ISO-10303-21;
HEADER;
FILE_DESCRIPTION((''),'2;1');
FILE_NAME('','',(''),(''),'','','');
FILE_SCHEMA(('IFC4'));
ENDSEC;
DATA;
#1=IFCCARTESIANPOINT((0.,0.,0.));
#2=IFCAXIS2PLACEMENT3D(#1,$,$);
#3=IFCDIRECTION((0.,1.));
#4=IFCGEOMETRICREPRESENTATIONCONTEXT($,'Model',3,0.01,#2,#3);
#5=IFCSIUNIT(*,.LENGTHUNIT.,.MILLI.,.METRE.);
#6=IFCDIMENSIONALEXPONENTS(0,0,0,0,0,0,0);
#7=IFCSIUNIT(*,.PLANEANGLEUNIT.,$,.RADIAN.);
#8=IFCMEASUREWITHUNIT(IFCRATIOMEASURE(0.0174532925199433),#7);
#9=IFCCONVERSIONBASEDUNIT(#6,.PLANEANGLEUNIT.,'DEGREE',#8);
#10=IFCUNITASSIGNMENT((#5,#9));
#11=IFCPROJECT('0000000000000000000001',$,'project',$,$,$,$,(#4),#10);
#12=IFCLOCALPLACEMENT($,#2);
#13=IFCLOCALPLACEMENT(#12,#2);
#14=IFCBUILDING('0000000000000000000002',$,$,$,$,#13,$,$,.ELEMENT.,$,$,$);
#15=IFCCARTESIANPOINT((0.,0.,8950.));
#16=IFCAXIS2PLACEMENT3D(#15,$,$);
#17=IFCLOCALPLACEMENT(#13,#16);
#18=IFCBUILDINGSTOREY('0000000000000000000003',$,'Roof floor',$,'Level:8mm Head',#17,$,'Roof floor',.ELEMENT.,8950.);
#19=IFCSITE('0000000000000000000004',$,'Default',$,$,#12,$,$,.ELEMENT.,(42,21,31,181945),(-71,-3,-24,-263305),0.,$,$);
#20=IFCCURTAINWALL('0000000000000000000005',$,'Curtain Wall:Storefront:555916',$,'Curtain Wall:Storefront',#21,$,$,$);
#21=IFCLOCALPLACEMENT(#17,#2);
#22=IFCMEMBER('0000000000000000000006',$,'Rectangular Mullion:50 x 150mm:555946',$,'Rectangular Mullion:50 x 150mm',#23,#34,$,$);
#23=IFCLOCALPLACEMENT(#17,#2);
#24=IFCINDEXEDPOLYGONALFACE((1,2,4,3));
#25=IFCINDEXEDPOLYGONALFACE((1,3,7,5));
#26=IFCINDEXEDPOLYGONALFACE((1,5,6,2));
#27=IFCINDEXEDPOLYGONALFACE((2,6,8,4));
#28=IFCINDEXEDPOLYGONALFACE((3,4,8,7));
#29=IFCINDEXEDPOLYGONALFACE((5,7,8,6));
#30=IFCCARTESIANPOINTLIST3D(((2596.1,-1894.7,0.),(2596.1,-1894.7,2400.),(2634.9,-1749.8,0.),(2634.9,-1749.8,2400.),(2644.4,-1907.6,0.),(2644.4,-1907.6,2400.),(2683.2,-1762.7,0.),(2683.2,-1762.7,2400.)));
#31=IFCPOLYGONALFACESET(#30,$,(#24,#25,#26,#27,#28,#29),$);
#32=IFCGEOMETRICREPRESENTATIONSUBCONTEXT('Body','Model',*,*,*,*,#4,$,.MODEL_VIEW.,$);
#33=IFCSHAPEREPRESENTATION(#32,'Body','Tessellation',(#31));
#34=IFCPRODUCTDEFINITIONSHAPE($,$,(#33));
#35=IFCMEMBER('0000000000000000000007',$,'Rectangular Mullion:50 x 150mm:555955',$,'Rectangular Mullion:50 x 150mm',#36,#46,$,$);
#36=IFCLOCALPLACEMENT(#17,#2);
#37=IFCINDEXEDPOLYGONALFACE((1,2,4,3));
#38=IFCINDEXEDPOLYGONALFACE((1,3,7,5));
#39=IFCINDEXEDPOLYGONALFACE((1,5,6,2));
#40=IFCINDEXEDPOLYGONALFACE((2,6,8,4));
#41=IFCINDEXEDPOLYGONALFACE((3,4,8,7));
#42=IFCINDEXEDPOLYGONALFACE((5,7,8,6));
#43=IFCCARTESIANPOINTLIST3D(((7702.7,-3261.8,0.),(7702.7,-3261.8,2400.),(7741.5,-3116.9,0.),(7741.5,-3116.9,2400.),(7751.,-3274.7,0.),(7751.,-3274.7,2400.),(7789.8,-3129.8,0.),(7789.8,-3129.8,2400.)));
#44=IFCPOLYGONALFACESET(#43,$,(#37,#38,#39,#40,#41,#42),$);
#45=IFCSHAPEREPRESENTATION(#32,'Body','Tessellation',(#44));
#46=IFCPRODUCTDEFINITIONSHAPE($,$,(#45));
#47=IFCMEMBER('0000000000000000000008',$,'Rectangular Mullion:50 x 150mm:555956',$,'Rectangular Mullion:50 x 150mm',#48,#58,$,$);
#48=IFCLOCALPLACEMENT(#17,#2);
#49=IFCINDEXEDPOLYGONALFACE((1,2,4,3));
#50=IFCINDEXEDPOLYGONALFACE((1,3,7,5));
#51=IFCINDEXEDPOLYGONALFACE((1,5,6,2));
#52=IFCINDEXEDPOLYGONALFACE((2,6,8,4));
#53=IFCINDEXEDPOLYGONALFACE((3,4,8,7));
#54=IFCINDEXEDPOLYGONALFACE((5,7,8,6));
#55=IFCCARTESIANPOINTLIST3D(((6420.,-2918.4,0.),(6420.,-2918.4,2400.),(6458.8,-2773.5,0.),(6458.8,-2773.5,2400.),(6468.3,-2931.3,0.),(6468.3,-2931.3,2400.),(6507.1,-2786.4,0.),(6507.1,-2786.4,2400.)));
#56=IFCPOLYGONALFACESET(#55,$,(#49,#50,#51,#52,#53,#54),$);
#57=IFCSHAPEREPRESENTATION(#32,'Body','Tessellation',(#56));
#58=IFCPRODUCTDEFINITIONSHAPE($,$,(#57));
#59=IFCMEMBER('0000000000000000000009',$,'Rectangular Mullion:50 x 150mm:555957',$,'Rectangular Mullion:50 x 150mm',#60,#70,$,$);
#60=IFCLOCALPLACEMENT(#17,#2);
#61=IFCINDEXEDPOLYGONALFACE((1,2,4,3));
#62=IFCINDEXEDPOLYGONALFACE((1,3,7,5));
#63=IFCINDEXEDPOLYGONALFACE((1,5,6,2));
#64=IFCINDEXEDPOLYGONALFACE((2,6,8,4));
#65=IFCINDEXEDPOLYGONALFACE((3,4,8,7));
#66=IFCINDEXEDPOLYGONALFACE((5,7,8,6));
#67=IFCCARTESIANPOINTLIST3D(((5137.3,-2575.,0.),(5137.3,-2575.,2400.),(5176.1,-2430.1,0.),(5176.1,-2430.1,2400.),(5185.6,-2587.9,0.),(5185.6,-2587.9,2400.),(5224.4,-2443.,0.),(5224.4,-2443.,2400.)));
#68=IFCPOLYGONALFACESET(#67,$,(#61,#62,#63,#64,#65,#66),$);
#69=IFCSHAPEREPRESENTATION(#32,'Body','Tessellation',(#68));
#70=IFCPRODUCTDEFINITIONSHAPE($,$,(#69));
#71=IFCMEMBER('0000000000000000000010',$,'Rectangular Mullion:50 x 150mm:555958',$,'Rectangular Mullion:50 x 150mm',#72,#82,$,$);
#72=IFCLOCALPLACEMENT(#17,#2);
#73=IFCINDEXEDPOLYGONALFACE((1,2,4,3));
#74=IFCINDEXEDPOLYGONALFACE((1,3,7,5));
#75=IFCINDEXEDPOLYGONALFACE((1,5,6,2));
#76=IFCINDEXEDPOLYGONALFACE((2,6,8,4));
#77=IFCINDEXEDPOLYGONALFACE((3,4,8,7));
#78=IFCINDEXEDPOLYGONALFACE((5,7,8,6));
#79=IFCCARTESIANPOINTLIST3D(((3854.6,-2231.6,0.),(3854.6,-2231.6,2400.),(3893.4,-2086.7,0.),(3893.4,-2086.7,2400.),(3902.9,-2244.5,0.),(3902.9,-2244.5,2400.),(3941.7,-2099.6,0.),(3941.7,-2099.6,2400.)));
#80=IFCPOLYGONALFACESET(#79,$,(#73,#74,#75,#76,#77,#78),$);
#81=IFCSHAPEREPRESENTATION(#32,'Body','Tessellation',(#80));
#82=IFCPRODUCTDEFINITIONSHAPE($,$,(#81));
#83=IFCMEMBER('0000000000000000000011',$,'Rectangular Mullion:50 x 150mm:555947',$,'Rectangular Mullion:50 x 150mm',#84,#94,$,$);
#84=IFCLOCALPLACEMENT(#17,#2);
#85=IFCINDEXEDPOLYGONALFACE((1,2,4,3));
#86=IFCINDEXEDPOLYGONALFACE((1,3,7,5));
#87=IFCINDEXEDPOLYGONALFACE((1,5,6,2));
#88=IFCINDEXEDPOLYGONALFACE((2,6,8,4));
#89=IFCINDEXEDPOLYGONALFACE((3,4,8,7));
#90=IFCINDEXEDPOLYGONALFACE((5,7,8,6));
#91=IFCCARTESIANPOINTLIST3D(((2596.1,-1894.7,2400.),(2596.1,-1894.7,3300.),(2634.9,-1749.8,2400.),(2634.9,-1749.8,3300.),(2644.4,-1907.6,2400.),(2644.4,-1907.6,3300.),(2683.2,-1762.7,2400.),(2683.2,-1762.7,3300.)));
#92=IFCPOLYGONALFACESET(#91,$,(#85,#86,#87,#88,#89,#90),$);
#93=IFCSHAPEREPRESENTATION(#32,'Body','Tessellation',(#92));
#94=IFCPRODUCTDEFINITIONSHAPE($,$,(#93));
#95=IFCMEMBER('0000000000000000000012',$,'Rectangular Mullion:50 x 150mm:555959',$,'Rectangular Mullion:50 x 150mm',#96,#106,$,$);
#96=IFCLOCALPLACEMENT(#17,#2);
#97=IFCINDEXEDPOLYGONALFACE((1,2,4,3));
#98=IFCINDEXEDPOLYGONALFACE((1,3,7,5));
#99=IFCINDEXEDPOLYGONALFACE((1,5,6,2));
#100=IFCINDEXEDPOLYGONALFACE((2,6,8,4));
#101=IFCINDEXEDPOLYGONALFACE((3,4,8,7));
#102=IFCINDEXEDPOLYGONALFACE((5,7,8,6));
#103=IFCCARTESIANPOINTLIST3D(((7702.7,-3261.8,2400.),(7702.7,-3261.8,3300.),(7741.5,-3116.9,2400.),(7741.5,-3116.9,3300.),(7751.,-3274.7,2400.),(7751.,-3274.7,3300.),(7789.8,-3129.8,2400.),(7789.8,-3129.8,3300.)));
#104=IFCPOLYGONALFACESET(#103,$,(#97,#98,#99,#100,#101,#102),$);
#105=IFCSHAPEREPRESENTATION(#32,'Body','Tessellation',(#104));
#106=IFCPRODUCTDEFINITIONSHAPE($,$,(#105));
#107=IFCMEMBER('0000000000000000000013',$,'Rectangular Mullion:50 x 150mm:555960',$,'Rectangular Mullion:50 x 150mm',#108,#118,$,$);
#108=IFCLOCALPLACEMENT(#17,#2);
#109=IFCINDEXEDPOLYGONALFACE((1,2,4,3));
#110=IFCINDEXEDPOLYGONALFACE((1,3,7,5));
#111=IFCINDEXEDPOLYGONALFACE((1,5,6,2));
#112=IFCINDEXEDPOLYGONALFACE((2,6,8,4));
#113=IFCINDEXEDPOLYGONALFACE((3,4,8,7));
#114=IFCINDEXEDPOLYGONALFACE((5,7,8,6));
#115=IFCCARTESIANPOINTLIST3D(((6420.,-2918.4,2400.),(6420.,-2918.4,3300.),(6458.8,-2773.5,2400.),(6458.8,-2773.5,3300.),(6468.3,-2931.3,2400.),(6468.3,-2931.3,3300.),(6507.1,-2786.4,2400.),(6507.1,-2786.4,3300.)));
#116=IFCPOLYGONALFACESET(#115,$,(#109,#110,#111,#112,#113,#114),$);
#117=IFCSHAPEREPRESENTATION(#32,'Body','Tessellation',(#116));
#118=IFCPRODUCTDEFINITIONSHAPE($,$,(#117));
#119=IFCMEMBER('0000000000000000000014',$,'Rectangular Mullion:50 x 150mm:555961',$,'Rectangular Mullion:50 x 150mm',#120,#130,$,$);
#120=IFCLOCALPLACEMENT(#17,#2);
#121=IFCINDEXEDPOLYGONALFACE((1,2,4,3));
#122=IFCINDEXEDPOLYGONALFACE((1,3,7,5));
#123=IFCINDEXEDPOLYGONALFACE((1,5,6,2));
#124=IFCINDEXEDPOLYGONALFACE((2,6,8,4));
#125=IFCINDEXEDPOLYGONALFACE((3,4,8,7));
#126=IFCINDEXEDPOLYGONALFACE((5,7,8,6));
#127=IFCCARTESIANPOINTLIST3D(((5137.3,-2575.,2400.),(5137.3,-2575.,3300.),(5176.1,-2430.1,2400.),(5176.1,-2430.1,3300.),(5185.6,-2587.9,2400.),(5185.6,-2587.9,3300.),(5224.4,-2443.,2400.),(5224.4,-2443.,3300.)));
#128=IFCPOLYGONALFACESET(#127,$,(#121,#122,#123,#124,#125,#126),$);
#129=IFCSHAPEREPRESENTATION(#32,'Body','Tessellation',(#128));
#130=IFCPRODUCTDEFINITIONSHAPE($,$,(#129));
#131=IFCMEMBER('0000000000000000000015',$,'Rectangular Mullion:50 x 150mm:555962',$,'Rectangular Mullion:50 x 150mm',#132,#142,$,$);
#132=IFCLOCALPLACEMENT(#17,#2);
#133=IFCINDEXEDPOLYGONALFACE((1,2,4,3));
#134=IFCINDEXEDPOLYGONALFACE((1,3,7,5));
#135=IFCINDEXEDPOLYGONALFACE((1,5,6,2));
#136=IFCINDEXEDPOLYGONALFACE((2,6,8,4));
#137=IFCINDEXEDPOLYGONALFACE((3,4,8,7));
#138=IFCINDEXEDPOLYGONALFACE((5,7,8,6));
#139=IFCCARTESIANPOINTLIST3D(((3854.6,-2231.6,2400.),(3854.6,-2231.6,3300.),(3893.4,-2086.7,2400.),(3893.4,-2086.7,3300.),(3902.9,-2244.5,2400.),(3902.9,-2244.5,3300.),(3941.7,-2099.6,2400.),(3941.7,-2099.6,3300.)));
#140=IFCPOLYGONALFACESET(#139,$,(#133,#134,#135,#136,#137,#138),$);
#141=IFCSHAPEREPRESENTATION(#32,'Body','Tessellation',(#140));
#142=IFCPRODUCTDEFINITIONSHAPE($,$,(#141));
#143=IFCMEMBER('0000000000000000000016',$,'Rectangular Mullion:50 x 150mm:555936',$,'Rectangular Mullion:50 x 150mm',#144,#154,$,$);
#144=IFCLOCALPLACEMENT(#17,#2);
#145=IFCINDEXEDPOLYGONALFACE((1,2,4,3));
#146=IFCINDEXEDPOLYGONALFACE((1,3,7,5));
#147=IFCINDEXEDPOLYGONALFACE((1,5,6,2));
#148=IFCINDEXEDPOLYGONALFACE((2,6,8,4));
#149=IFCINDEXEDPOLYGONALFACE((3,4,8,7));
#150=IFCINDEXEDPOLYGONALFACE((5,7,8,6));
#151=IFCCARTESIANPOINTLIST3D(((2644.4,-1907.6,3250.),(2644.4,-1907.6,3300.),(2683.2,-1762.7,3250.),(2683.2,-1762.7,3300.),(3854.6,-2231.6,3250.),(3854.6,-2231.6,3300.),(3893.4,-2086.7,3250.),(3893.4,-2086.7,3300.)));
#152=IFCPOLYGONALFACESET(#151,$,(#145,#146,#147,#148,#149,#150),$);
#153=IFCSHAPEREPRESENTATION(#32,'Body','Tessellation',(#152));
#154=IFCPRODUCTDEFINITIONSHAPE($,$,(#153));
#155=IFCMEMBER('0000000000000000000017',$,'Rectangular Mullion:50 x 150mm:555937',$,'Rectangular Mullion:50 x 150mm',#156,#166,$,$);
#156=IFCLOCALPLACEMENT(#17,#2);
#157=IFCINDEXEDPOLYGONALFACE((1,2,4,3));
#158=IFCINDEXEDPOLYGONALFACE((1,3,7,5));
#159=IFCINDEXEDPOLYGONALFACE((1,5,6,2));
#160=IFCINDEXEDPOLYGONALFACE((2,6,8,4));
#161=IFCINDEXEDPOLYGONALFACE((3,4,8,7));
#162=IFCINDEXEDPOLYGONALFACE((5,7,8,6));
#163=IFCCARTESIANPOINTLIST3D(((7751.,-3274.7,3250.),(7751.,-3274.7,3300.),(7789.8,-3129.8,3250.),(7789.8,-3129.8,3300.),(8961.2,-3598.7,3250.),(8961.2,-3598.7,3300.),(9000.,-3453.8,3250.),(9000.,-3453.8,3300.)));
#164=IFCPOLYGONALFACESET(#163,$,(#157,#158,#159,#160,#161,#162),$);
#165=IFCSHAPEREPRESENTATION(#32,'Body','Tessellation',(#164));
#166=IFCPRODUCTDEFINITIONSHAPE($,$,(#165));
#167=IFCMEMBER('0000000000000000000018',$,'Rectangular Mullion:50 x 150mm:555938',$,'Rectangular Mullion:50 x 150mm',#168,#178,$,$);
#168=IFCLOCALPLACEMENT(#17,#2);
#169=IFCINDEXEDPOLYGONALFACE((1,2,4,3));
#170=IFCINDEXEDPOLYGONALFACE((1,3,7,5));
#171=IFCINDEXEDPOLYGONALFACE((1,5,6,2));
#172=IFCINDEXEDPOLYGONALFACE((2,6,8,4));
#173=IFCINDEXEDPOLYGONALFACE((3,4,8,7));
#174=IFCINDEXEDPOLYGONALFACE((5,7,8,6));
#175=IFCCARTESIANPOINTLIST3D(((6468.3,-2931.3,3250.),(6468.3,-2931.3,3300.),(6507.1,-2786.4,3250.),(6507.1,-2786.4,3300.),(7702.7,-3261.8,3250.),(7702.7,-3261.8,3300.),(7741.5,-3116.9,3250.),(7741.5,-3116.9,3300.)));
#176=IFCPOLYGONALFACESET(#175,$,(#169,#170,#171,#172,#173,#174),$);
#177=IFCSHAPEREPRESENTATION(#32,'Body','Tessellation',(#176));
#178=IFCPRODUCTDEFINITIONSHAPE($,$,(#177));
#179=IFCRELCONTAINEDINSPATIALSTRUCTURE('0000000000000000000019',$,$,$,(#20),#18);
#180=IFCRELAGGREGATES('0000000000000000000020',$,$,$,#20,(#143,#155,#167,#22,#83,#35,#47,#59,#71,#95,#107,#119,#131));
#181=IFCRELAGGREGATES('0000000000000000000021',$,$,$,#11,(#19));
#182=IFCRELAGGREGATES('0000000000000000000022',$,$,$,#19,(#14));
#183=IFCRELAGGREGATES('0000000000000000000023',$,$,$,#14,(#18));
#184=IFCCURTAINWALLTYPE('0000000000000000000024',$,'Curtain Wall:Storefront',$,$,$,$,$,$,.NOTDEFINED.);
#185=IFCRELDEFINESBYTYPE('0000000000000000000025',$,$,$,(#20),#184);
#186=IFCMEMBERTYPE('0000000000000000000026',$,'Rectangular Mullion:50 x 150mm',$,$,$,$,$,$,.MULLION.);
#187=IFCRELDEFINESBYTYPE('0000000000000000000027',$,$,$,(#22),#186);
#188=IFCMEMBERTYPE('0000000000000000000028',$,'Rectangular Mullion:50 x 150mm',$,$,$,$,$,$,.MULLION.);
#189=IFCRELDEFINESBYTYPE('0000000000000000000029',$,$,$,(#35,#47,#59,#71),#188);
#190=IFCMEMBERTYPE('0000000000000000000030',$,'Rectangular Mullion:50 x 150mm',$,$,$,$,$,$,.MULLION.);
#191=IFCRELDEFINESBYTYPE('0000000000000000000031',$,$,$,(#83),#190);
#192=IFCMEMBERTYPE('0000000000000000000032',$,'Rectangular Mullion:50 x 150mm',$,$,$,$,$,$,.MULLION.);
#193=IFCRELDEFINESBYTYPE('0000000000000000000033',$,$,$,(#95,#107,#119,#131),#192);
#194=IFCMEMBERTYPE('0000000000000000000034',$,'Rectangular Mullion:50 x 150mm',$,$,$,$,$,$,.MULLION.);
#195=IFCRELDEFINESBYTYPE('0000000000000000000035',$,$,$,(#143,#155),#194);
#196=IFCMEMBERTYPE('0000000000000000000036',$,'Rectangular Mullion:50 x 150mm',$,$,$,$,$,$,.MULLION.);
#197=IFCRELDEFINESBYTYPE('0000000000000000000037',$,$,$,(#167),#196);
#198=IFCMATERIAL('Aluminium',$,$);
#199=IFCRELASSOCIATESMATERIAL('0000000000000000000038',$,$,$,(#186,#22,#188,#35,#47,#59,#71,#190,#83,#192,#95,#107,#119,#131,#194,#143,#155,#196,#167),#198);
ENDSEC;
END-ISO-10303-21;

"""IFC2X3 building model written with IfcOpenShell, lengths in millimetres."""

from ifc_helpers import new_model, entity, si_unit, converted_unit, direction, frame, origin, origin_2d_with_axis, place, context, subcontext, project, spatial, rectangle, extrude, source, transform, mapped, material, type_object, type_shapes, element, aggregate, save


model = new_model("IFC2X3")

# Units and contexts
model_context = context("Model", 3, precision=0.01, world=origin(), true_north=direction((0.0, 1.0)))
body_context = subcontext(model_context, "Body", "Model", "MODEL_VIEW")
ifc_project = project(units=[si_unit("LENGTHUNIT", "METRE", prefix="MILLI"), converted_unit("PLANEANGLEUNIT", "DEGREE", entity("IfcRatioMeasure", 0.0174532925199433), si_unit("PLANEANGLEUNIT", "RADIAN"), dimensions=[0, 0, 0, 0, 0, 0, 0])], contexts=[model_context])

# Site, building, storey
site_placement = place(None, origin())
site = spatial("IfcSite", under=ifc_project, at=site_placement, Name="Default", CompositionType="ELEMENT", RefLatitude=(42, 21, 31, 181945), RefLongitude=(-71, -3, -24, -263305), RefElevation=0.0)
building_placement = place(site_placement, origin())
building = spatial("IfcBuilding", under=site, at=building_placement, CompositionType="ELEMENT")
storey_placement = place(building_placement, frame((0.0, 0.0, 8950.0)))
storey = spatial("IfcBuildingStorey", under=building, at=storey_placement, Name="Roof floor", ObjectType="Level:8mm Head", LongName="Roof floor", CompositionType="ELEMENT", Elevation=8950.0)

# Curtain wall, members
curtain_wall_type = type_object("IfcCurtainWallType", Name="Curtain Wall:Storefront", PredefinedType="NOTDEFINED")
curtain_wall_placement = place(storey_placement, frame((0.0, 0.0, -8950.0)))
curtain_wall = element("IfcCurtainWall", 1, at=curtain_wall_placement, inside=storey, type_object=curtain_wall_type, Name="Curtain Wall:Storefront:555916", ObjectType="Curtain Wall:Storefront")
ifc_material_1 = material(Name="Aluminium")
member_type_1 = type_object("IfcMemberType", Name="Rectangular Mullion:50 x 150mm", PredefinedType="MULLION", material=ifc_material_1)
shared_shape_1 = source(origin(), body_context, "Body", "SweptSolid", [
    extrude(rectangle(XDim=150.0, YDim=50.0, at=origin_2d_with_axis()), frame((-25.0, 0.0, -2400.0), z_axis=(0.0, 0.0, 1.0), x_axis=(0.0, -1.0, 0.0)), (0.0, 0.0, 1.0), 2400.0),
])
type_shapes(member_type_1, [shared_shape_1])
member_1_placement = place(storey_placement, frame((2615.5, -1822.2, 0.0), z_axis=(0.0, 0.0, -1.0), x_axis=(-0.965983, 0.258607, 0.0)))
member_1 = element("IfcMember", 2, at=member_1_placement, type_object=member_type_1, material=ifc_material_1, Name="Rectangular Mullion:50 x 150mm:555946", ObjectType="Rectangular Mullion:50 x 150mm", context=body_context, shape_type="MappedRepresentation", body=[
    mapped(shared_shape_1, transform((0.0, 0.0, 0.0), scale=1.0)),
])
member_type_2 = type_object("IfcMemberType", Name="Rectangular Mullion:50 x 150mm", PredefinedType="MULLION", material=ifc_material_1)
shared_shape_2 = source(origin(), body_context, "Body", "SweptSolid", [
    extrude(rectangle(XDim=150.0, YDim=50.0, at=origin_2d_with_axis()), frame((0.0, 0.0, -2400.0), z_axis=(0.0, 0.0, 1.0), x_axis=(0.0, -1.0, 0.0)), (0.0, 0.0, 1.0), 2400.0),
])
type_shapes(member_type_2, [shared_shape_2])
member_2_placement = place(storey_placement, frame((7746.2, -3195.8, 0.0), z_axis=(0.0, 0.0, -1.0), x_axis=(-0.965983, 0.258607, 0.0)))
member_2 = element("IfcMember", 3, at=member_2_placement, type_object=member_type_2, material=ifc_material_1, Name="Rectangular Mullion:50 x 150mm:555955", ObjectType="Rectangular Mullion:50 x 150mm", context=body_context, shape_type="MappedRepresentation", body=[
    mapped(shared_shape_2, transform((0.0, 0.0, 0.0), scale=1.0)),
])
member_3_placement = place(storey_placement, frame((6463.5, -2852.4, 0.0), z_axis=(0.0, 0.0, -1.0), x_axis=(-0.965983, 0.258607, 0.0)))
member_3 = element("IfcMember", 4, at=member_3_placement, type_object=member_type_2, material=ifc_material_1, Name="Rectangular Mullion:50 x 150mm:555956", ObjectType="Rectangular Mullion:50 x 150mm", context=body_context, shape_type="MappedRepresentation", body=[
    mapped(shared_shape_2, transform((0.0, 0.0, 0.0), scale=1.0)),
])
member_4_placement = place(storey_placement, frame((5180.8, -2509.0, 0.0), z_axis=(0.0, 0.0, -1.0), x_axis=(-0.965983, 0.258607, 0.0)))
member_4 = element("IfcMember", 5, at=member_4_placement, type_object=member_type_2, material=ifc_material_1, Name="Rectangular Mullion:50 x 150mm:555957", ObjectType="Rectangular Mullion:50 x 150mm", context=body_context, shape_type="MappedRepresentation", body=[
    mapped(shared_shape_2, transform((0.0, 0.0, 0.0), scale=1.0)),
])
member_5_placement = place(storey_placement, frame((3898.2, -2165.6, 0.0), z_axis=(0.0, 0.0, -1.0), x_axis=(-0.965983, 0.258607, 0.0)))
member_5 = element("IfcMember", 6, at=member_5_placement, type_object=member_type_2, material=ifc_material_1, Name="Rectangular Mullion:50 x 150mm:555958", ObjectType="Rectangular Mullion:50 x 150mm", context=body_context, shape_type="MappedRepresentation", body=[
    mapped(shared_shape_2, transform((0.0, 0.0, 0.0), scale=1.0)),
])
member_type_3 = type_object("IfcMemberType", Name="Rectangular Mullion:50 x 150mm", PredefinedType="MULLION", material=ifc_material_1)
shared_shape_3 = source(origin(), body_context, "Body", "SweptSolid", [
    extrude(rectangle(XDim=150.0, YDim=50.0, at=origin_2d_with_axis()), frame((-25.0, 0.0, -900.0), z_axis=(0.0, 0.0, 1.0), x_axis=(0.0, -1.0, 0.0)), (0.0, 0.0, 1.0), 900.0),
])
type_shapes(member_type_3, [shared_shape_3])
member_6_placement = place(storey_placement, frame((2615.5, -1822.2, 2400.0), z_axis=(0.0, 0.0, -1.0), x_axis=(-0.965983, 0.258607, 0.0)))
member_6 = element("IfcMember", 7, at=member_6_placement, type_object=member_type_3, material=ifc_material_1, Name="Rectangular Mullion:50 x 150mm:555947", ObjectType="Rectangular Mullion:50 x 150mm", context=body_context, shape_type="MappedRepresentation", body=[
    mapped(shared_shape_3, transform((0.0, 0.0, 0.0), scale=1.0)),
])
member_type_4 = type_object("IfcMemberType", Name="Rectangular Mullion:50 x 150mm", PredefinedType="MULLION", material=ifc_material_1)
shared_shape_4 = source(origin(), body_context, "Body", "SweptSolid", [
    extrude(rectangle(XDim=150.0, YDim=50.0, at=origin_2d_with_axis()), frame((0.0, 0.0, -900.0), z_axis=(0.0, 0.0, 1.0), x_axis=(0.0, -1.0, 0.0)), (0.0, 0.0, 1.0), 900.0),
])
type_shapes(member_type_4, [shared_shape_4])
member_7_placement = place(storey_placement, frame((7746.2, -3195.8, 2400.0), z_axis=(0.0, 0.0, -1.0), x_axis=(-0.965983, 0.258607, 0.0)))
member_7 = element("IfcMember", 8, at=member_7_placement, type_object=member_type_4, material=ifc_material_1, Name="Rectangular Mullion:50 x 150mm:555959", ObjectType="Rectangular Mullion:50 x 150mm", context=body_context, shape_type="MappedRepresentation", body=[
    mapped(shared_shape_4, transform((0.0, 0.0, 0.0), scale=1.0)),
])
member_8_placement = place(storey_placement, frame((6463.5, -2852.4, 2400.0), z_axis=(0.0, 0.0, -1.0), x_axis=(-0.965983, 0.258607, 0.0)))
member_8 = element("IfcMember", 9, at=member_8_placement, type_object=member_type_4, material=ifc_material_1, Name="Rectangular Mullion:50 x 150mm:555960", ObjectType="Rectangular Mullion:50 x 150mm", context=body_context, shape_type="MappedRepresentation", body=[
    mapped(shared_shape_4, transform((0.0, 0.0, 0.0), scale=1.0)),
])
member_9_placement = place(storey_placement, frame((5180.8, -2509.0, 2400.0), z_axis=(0.0, 0.0, -1.0), x_axis=(-0.965983, 0.258607, 0.0)))
member_9 = element("IfcMember", 10, at=member_9_placement, type_object=member_type_4, material=ifc_material_1, Name="Rectangular Mullion:50 x 150mm:555961", ObjectType="Rectangular Mullion:50 x 150mm", context=body_context, shape_type="MappedRepresentation", body=[
    mapped(shared_shape_4, transform((0.0, 0.0, 0.0), scale=1.0)),
])
member_10_placement = place(storey_placement, frame((3898.2, -2165.6, 2400.0), z_axis=(0.0, 0.0, -1.0), x_axis=(-0.965983, 0.258607, 0.0)))
member_10 = element("IfcMember", 11, at=member_10_placement, type_object=member_type_4, material=ifc_material_1, Name="Rectangular Mullion:50 x 150mm:555962", ObjectType="Rectangular Mullion:50 x 150mm", context=body_context, shape_type="MappedRepresentation", body=[
    mapped(shared_shape_4, transform((0.0, 0.0, 0.0), scale=1.0)),
])
member_type_5 = type_object("IfcMemberType", Name="Rectangular Mullion:50 x 150mm", PredefinedType="MULLION", material=ifc_material_1)
shared_shape_5 = source(origin(), body_context, "Body", "SweptSolid", [
    extrude(rectangle(XDim=150.0, YDim=50.0, at=origin_2d_with_axis()), frame((-25.0, 0.0, -1252.9), z_axis=(0.0, 0.0, 1.0), x_axis=(0.0, -1.0, 0.0)), (0.0, 0.0, 1.0), 1252.9),
])
type_shapes(member_type_5, [shared_shape_5])
member_11_placement = place(storey_placement, frame((2663.8, -1835.1, 3300.0), z_axis=(-0.965983, 0.258607, 0.0), x_axis=(0.0, 0.0, 1.0)))
member_11 = element("IfcMember", 12, at=member_11_placement, type_object=member_type_5, material=ifc_material_1, Name="Rectangular Mullion:50 x 150mm:555936", ObjectType="Rectangular Mullion:50 x 150mm", context=body_context, shape_type="MappedRepresentation", body=[
    mapped(shared_shape_5, transform((0.0, 0.0, 0.0), scale=1.0)),
])
member_12_placement = place(storey_placement, frame((7770.4, -3202.3, 3300.0), z_axis=(-0.965983, 0.258607, 0.0), x_axis=(0.0, 0.0, 1.0)))
member_12 = element("IfcMember", 13, at=member_12_placement, type_object=member_type_5, material=ifc_material_1, Name="Rectangular Mullion:50 x 150mm:555937", ObjectType="Rectangular Mullion:50 x 150mm", context=body_context, shape_type="MappedRepresentation", body=[
    mapped(shared_shape_5, transform((0.0, 0.0, 0.0), scale=1.0)),
])
member_type_6 = type_object("IfcMemberType", Name="Rectangular Mullion:50 x 150mm", PredefinedType="MULLION", material=ifc_material_1)
shared_shape_6 = source(origin(), body_context, "Body", "SweptSolid", [
    extrude(rectangle(XDim=150.0, YDim=50.0, at=origin_2d_with_axis()), frame((-25.0, 0.0, -1277.9), z_axis=(0.0, 0.0, 1.0), x_axis=(0.0, -1.0, 0.0)), (0.0, 0.0, 1.0), 1277.9),
])
type_shapes(member_type_6, [shared_shape_6])
member_13_placement = place(storey_placement, frame((6487.7, -2858.9, 3300.0), z_axis=(-0.965983, 0.258607, 0.0), x_axis=(0.0, 0.0, 1.0)))
member_13 = element("IfcMember", 14, at=member_13_placement, type_object=member_type_6, material=ifc_material_1, Name="Rectangular Mullion:50 x 150mm:555938", ObjectType="Rectangular Mullion:50 x 150mm", context=body_context, shape_type="MappedRepresentation", body=[
    mapped(shared_shape_6, transform((0.0, 0.0, 0.0), scale=1.0)),
])
aggregate(curtain_wall, [member_11, member_12, member_13, member_1, member_6, member_2, member_3, member_4, member_5, member_7, member_8, member_9, member_10])

save(model, "model.ifc")
